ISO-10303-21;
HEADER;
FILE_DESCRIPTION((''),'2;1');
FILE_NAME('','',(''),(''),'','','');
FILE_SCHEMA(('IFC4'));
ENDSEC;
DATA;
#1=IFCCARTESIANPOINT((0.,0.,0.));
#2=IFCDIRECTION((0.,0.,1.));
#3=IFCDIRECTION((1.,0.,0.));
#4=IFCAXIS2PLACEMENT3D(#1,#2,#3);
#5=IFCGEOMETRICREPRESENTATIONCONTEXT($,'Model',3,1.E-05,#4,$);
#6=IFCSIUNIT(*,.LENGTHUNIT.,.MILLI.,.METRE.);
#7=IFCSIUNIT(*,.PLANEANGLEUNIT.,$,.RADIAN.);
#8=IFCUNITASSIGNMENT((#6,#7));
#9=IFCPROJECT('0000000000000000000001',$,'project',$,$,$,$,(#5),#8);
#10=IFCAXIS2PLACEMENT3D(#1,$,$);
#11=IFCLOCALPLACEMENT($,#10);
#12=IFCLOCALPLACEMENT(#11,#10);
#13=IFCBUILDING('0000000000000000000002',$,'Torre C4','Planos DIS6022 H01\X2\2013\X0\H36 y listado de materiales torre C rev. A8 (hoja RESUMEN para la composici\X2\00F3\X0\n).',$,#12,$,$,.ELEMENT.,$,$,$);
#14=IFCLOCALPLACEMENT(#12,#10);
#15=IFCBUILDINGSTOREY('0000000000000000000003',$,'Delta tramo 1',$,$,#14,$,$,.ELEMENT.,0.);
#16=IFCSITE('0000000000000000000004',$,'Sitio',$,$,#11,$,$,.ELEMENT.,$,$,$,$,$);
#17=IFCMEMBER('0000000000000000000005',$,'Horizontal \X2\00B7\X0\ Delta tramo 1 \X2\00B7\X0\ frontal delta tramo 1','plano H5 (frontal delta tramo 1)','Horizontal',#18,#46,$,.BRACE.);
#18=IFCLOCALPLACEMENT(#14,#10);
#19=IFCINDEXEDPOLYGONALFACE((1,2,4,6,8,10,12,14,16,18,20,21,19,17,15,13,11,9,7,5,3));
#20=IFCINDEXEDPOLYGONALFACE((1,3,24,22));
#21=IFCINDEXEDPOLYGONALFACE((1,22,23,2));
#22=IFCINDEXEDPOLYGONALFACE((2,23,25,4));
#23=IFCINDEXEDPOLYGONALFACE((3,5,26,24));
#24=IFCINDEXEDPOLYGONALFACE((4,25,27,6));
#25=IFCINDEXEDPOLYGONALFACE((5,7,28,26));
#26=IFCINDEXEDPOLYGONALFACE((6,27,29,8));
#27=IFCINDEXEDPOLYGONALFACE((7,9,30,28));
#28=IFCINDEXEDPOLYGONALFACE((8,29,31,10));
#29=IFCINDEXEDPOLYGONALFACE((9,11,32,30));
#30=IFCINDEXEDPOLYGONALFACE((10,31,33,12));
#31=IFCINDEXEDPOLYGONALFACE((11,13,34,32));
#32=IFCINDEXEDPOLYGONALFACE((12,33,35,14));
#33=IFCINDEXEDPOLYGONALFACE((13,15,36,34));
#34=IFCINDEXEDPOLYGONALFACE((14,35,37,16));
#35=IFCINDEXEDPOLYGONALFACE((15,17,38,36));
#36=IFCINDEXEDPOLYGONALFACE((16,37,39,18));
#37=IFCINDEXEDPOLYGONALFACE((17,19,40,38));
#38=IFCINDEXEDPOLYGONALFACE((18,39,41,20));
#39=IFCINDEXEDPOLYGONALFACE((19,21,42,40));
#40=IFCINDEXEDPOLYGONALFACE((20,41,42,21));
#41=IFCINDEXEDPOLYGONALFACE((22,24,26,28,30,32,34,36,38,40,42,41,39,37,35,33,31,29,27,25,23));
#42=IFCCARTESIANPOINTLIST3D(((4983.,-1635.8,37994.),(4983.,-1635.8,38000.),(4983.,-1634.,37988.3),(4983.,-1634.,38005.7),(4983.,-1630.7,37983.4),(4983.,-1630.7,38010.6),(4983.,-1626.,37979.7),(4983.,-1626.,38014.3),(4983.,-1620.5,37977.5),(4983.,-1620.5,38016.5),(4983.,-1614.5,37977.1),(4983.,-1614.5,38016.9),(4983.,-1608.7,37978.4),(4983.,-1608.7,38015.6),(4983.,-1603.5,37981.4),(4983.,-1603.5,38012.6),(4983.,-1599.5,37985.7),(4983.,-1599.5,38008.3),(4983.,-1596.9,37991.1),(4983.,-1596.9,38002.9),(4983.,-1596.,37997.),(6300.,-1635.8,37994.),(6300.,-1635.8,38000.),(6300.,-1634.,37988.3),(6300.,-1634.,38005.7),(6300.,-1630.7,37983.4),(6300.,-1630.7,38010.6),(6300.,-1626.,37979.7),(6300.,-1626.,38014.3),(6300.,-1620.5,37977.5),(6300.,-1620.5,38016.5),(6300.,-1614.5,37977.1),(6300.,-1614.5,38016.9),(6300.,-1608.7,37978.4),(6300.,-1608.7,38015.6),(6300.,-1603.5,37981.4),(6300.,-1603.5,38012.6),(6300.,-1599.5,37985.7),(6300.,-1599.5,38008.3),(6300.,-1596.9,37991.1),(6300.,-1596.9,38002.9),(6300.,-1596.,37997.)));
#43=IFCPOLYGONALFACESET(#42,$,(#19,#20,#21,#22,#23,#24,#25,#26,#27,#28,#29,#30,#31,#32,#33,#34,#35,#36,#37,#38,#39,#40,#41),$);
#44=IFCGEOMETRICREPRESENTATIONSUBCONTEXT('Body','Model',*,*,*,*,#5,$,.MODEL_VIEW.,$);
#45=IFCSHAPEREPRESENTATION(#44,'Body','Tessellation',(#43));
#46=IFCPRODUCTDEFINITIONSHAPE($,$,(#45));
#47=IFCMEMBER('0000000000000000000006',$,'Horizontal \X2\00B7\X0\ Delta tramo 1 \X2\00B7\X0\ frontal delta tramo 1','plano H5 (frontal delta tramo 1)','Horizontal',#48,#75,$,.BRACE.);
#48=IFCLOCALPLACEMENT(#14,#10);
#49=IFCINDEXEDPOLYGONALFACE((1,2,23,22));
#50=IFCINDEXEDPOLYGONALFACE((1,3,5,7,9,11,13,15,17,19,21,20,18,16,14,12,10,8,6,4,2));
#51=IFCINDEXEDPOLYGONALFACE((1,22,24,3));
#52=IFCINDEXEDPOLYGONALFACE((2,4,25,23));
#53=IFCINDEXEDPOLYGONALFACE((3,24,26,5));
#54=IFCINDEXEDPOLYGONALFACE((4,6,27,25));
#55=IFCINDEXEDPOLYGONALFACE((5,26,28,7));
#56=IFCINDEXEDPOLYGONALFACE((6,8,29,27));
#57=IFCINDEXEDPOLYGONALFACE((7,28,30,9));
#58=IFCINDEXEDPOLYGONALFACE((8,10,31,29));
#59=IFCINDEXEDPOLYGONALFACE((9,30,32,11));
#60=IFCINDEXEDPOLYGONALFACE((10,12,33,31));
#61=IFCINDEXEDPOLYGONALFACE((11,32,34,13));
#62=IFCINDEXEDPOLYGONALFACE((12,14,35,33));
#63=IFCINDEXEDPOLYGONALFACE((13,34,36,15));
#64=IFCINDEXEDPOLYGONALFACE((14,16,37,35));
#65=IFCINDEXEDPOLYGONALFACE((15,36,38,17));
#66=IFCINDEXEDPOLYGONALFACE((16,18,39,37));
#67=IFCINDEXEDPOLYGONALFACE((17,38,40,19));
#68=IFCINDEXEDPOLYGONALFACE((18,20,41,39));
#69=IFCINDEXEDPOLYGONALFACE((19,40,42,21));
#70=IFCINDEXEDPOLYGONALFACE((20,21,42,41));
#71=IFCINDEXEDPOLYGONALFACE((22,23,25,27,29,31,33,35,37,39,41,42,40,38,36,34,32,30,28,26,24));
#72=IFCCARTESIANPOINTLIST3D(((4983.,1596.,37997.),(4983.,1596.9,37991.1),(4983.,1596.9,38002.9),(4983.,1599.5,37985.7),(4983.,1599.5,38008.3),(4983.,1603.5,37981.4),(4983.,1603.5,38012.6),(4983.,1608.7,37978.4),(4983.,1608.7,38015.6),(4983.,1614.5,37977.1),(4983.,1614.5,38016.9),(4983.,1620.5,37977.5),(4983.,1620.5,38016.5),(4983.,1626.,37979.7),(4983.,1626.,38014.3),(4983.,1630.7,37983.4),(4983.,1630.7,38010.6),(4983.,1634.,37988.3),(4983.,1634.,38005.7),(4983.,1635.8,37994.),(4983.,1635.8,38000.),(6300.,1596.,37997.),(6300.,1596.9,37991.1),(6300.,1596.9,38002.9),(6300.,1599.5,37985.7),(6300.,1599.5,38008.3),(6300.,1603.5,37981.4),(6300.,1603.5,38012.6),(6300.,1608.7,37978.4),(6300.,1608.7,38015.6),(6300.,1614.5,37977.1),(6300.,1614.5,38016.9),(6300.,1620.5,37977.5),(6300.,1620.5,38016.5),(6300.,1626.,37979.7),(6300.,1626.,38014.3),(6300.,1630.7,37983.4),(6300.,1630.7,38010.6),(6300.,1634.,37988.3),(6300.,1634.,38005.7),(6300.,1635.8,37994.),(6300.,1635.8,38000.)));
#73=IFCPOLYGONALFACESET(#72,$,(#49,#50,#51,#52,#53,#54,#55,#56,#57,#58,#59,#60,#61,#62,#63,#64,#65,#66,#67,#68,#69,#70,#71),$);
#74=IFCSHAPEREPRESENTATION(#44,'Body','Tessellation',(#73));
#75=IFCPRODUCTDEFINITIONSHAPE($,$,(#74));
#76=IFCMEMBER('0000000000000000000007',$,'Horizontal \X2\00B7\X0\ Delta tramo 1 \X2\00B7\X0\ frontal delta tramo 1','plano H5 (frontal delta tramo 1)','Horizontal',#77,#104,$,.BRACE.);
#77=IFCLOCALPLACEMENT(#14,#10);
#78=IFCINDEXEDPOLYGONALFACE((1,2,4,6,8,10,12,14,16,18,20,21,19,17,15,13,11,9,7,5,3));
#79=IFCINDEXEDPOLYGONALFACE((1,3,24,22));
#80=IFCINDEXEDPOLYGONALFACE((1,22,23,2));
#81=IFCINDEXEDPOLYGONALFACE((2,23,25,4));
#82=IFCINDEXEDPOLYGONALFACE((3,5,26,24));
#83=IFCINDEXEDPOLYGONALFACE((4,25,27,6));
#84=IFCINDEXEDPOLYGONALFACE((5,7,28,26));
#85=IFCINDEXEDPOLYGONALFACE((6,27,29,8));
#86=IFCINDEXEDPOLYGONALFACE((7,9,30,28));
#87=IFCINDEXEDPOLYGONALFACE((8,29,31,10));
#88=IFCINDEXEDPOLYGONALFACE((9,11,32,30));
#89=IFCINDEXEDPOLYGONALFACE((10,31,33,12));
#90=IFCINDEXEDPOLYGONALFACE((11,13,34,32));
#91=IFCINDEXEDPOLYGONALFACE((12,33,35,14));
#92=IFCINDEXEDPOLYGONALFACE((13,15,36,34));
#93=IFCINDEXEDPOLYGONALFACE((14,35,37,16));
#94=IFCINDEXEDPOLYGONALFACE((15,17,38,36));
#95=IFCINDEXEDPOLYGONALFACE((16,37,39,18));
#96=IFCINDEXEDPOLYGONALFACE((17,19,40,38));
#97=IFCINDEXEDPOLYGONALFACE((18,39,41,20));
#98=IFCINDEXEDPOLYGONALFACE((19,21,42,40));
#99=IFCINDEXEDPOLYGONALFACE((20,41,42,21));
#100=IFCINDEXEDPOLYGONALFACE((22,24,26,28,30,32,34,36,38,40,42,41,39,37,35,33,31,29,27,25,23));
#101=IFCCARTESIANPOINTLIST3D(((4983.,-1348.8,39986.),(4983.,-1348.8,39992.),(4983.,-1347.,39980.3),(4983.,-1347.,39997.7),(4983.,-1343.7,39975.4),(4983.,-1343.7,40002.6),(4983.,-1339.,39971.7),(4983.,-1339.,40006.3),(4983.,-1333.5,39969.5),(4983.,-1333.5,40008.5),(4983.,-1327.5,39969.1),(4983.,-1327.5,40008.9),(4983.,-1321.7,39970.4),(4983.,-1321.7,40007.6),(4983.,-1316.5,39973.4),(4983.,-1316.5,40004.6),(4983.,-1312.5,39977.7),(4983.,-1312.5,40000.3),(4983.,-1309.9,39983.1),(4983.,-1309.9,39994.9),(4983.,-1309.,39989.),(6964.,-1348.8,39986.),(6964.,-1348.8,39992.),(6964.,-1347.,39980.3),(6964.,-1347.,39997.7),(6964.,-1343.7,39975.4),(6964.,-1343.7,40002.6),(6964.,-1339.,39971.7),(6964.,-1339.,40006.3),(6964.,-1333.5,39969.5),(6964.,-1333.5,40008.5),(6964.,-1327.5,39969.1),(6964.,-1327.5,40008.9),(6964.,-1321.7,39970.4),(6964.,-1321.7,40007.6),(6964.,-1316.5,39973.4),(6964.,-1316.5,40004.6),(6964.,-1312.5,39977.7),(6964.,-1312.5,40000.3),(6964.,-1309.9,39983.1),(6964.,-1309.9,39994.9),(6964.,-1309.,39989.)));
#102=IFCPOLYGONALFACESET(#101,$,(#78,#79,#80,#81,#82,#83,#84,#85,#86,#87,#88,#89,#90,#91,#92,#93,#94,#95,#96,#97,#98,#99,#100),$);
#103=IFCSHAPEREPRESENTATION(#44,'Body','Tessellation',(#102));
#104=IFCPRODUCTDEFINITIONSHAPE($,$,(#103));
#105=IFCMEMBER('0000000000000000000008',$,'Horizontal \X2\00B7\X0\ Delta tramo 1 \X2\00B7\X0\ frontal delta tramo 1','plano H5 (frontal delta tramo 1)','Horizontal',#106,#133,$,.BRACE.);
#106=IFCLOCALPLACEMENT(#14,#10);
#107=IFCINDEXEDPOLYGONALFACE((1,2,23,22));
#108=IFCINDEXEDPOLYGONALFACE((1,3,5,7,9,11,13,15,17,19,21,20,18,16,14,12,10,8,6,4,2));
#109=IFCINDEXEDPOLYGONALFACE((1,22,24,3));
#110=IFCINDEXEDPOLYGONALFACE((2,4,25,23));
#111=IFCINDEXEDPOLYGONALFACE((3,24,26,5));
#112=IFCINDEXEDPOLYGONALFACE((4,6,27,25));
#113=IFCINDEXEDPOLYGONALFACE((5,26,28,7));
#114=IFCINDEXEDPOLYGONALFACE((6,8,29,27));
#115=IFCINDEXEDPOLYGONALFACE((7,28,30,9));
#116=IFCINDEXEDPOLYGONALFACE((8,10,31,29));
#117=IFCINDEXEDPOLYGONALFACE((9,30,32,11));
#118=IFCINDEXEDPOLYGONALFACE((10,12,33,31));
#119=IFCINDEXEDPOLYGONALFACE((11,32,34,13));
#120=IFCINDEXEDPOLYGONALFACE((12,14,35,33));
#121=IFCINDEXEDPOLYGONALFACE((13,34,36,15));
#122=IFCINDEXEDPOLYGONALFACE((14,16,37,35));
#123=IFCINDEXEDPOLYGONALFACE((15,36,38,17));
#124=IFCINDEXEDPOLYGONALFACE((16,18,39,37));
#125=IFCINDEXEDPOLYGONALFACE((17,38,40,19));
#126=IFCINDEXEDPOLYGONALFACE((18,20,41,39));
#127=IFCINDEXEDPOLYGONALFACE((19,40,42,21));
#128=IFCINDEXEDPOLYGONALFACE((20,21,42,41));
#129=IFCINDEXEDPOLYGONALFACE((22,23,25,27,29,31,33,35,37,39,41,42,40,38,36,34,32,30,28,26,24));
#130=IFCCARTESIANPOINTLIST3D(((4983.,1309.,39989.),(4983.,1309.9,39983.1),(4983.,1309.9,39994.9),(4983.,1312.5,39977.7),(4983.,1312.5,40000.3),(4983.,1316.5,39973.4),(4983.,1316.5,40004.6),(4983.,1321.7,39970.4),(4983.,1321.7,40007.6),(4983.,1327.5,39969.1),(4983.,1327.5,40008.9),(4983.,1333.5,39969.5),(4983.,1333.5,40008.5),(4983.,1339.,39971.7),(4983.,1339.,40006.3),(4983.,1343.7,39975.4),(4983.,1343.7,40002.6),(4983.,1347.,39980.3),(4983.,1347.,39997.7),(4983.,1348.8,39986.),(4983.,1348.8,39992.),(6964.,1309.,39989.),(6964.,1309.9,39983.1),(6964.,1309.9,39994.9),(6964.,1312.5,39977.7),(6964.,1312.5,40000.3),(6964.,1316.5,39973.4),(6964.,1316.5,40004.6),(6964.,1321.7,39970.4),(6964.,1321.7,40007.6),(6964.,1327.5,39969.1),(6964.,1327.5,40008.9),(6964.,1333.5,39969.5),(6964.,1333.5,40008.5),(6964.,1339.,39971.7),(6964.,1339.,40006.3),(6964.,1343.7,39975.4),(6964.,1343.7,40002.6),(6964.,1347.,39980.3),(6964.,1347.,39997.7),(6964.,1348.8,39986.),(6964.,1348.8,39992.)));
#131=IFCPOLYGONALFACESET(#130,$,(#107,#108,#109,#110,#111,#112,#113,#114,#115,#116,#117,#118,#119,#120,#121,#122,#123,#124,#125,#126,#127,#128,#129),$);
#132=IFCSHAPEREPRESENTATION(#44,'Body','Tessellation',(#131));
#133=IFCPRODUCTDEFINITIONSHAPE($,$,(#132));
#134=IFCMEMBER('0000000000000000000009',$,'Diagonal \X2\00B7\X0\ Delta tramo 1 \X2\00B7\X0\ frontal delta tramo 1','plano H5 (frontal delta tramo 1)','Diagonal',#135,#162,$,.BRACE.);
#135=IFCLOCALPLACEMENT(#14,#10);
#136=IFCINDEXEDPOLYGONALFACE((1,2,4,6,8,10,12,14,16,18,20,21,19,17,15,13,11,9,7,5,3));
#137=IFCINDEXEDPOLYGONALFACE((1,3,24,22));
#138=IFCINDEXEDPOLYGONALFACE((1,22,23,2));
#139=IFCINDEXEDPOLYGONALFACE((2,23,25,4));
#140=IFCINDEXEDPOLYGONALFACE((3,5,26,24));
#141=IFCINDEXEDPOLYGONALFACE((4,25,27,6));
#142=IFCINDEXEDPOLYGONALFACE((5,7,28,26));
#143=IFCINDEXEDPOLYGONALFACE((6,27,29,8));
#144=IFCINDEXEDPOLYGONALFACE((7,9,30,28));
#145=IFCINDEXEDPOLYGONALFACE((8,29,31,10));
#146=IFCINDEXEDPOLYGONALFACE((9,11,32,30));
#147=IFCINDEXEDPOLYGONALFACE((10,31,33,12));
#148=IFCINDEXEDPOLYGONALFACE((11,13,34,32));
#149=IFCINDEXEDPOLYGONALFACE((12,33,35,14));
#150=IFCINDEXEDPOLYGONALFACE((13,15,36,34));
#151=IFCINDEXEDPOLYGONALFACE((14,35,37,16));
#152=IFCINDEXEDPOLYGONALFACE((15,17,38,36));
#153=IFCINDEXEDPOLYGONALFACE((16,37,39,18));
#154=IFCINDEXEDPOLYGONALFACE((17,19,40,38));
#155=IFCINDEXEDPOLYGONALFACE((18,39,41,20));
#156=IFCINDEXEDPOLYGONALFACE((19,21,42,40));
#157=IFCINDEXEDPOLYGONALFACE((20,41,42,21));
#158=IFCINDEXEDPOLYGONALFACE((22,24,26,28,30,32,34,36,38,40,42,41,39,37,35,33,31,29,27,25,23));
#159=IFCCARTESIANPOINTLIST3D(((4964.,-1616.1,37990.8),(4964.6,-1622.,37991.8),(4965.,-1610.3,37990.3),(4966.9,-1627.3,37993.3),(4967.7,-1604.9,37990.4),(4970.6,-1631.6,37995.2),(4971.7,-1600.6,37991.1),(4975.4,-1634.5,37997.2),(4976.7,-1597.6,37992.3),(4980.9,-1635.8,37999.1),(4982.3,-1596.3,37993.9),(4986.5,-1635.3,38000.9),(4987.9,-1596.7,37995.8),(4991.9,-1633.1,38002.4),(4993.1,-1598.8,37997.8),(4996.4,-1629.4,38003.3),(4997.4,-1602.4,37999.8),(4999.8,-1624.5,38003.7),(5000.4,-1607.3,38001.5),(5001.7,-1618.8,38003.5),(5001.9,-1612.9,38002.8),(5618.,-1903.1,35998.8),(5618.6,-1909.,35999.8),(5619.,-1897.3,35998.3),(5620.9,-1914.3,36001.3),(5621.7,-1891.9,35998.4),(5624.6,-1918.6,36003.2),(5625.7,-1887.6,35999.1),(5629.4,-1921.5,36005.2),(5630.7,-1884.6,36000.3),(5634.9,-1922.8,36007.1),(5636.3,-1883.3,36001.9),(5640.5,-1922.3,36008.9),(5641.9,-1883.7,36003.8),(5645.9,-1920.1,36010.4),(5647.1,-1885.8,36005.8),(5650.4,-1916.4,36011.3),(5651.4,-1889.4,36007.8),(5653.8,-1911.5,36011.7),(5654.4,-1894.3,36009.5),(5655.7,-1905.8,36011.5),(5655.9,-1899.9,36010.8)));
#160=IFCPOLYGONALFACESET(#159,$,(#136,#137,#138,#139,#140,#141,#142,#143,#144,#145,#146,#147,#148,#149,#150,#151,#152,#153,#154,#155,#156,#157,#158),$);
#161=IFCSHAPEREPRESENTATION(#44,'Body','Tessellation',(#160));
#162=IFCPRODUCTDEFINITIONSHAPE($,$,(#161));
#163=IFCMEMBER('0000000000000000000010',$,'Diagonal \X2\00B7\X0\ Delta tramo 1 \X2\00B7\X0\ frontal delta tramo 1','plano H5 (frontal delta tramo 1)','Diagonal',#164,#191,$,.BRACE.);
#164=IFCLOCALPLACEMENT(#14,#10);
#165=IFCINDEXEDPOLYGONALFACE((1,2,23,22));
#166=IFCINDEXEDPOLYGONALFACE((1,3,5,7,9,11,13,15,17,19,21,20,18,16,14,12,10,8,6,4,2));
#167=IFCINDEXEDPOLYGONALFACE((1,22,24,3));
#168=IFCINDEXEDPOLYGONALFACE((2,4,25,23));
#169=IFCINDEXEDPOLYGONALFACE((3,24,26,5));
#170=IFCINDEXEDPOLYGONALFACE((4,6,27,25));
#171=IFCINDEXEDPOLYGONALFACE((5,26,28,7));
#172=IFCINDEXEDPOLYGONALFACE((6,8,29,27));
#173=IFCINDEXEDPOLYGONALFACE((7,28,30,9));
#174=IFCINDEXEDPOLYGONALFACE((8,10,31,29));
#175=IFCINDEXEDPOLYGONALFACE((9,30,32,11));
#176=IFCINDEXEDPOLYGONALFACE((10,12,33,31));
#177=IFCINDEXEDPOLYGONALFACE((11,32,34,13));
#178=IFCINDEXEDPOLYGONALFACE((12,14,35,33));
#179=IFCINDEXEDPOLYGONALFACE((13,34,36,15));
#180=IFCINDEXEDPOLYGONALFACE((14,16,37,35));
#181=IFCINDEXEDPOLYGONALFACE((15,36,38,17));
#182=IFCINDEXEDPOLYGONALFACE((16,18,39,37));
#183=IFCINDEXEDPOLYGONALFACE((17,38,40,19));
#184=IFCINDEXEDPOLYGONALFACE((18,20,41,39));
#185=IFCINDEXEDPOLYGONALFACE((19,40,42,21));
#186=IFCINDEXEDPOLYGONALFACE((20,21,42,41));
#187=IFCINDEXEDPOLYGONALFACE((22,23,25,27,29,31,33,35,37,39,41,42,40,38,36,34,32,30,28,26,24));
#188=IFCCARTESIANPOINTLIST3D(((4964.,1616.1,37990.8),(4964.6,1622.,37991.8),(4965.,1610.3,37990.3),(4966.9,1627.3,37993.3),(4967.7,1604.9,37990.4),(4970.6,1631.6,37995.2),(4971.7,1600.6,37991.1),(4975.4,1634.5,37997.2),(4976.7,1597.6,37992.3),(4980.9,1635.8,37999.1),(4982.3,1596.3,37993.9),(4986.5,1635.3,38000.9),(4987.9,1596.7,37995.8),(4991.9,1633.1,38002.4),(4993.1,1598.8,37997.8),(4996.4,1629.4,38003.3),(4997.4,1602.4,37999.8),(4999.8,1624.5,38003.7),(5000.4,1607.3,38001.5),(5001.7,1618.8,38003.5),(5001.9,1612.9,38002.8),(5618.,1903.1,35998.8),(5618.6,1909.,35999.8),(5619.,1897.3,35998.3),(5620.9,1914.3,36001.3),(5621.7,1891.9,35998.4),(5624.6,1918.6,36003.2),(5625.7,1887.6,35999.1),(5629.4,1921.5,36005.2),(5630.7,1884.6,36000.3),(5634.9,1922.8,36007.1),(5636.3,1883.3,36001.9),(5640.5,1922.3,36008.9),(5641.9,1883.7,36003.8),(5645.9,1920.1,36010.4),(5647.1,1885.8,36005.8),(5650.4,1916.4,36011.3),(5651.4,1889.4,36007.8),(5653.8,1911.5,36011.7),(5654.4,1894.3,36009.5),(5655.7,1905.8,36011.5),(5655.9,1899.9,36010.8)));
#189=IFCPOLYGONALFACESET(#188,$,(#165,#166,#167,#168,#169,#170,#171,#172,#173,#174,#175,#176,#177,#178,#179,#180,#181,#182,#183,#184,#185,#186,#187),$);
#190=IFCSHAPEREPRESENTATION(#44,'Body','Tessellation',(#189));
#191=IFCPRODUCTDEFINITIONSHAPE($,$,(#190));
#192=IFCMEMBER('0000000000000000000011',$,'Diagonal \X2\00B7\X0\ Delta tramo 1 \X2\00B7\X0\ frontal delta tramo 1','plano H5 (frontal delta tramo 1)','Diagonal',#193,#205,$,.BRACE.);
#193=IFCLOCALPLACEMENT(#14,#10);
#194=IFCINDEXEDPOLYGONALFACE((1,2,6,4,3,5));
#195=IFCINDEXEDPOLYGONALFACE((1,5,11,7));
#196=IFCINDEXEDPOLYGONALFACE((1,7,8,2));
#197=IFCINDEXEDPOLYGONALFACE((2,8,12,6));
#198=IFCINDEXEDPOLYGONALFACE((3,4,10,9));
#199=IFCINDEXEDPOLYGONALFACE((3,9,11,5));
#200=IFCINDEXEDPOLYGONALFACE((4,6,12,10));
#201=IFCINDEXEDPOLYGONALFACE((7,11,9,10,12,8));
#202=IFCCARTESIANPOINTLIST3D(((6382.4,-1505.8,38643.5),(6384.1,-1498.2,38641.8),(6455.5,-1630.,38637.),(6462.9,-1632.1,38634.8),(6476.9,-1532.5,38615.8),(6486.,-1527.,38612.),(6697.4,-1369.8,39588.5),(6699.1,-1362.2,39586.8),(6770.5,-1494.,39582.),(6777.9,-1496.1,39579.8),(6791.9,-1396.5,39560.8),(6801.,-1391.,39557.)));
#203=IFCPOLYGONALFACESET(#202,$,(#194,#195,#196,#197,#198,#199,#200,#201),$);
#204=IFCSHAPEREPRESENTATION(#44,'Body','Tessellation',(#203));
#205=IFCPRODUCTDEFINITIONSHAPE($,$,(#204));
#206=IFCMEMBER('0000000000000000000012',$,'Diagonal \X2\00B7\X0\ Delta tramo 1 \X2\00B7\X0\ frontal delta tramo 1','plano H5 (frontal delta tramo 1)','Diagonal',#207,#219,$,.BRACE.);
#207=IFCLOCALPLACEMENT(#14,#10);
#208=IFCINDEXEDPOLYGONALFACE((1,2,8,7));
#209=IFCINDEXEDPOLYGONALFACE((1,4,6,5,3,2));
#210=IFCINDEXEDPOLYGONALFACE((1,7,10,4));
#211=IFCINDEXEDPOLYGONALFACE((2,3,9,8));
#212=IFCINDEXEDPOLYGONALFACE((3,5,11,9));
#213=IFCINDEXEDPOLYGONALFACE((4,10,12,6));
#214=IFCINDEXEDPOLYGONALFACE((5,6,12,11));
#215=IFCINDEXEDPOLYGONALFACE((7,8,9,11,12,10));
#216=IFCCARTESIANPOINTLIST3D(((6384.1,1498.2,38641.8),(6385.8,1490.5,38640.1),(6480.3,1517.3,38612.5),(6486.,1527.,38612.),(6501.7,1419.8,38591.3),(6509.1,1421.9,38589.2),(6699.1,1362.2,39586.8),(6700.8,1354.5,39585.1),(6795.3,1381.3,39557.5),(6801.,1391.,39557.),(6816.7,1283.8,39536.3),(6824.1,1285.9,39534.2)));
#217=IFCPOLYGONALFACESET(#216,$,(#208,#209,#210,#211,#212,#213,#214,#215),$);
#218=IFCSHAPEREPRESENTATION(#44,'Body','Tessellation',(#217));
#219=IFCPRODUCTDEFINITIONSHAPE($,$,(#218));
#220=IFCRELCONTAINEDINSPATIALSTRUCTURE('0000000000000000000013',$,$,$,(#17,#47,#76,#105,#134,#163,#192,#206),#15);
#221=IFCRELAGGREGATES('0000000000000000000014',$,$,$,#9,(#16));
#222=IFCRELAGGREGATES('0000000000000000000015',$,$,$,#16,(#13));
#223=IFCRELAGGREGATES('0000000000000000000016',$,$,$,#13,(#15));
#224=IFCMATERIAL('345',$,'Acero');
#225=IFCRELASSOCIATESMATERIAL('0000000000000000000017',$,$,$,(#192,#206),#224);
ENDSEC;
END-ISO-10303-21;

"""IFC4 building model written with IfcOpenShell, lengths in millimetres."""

from ifc_helpers import new_model, si_unit, frame, frame_2d, origin, origin_with_axes, place, context, subcontext, project, spatial, circle, l_section, extrude, material, element, save


model = new_model("IFC4")

# Units and contexts
model_context = context("Model", 3, precision=1e-05, world=origin_with_axes())
body_context = subcontext(model_context, "Body", "Model", "MODEL_VIEW")
ifc_project = project(units=[si_unit("LENGTHUNIT", "METRE", prefix="MILLI"), si_unit("PLANEANGLEUNIT", "RADIAN")], contexts=[model_context])

# Site, building, storey
site_placement = place(None, origin())
site = spatial("IfcSite", under=ifc_project, at=site_placement, Name="Sitio", CompositionType="ELEMENT")
building_placement = place(site_placement, origin())
building = spatial("IfcBuilding", under=site, at=building_placement, Name="Torre C4", Description="Planos DIS6022 H01–H36 y listado de materiales torre C rev. A8 (hoja RESUMEN para la composición).", CompositionType="ELEMENT")
storey_placement = place(building_placement, origin())
storey = spatial("IfcBuildingStorey", under=building, at=storey_placement, Name="Delta tramo 1", CompositionType="ELEMENT", Elevation=0.0)

# Members
for number, where, z_axis, x_axis, name in (
    (1, (6300.0, -1616.0, 37997.0), (-1.0, 0.0, 0.0), (0.0, 1.0, 0.0), "Horizontal · Delta tramo 1 · frontal delta tramo 1"),
    (2, (6300.0, 1616.0, 37997.0), (-1.0, 0.0, 0.0), (0.0, -1.0, 0.0), "Horizontal · Delta tramo 1 · frontal delta tramo 1"),
):
    element("IfcMember", number, at=place(storey_placement, frame(where, z_axis=z_axis, x_axis=x_axis)), inside=storey, Name=name, Description="plano H5 (frontal delta tramo 1)", ObjectType="Horizontal", PredefinedType="BRACE", context=body_context, shape_type="SweptSolid", body=[
        extrude(circle(Radius=20.0), None, (0.0, 0.0, 1.0), 1317.0),
    ])
for number, where, z_axis, x_axis, name in (
    (3, (6964.0, -1329.0, 39989.0), (-1.0, 0.0, 0.0), (0.0, 1.0, 0.0), "Horizontal · Delta tramo 1 · frontal delta tramo 1"),
    (4, (6964.0, 1329.0, 39989.0), (-1.0, 0.0, 0.0), (0.0, -1.0, 0.0), "Horizontal · Delta tramo 1 · frontal delta tramo 1"),
):
    element("IfcMember", number, at=place(storey_placement, frame(where, z_axis=z_axis, x_axis=x_axis)), inside=storey, Name=name, Description="plano H5 (frontal delta tramo 1)", ObjectType="Horizontal", PredefinedType="BRACE", context=body_context, shape_type="SweptSolid", body=[
        extrude(circle(Radius=20.0), None, (0.0, 0.0, 1.0), 1981.0),
    ])
for number, where, z_axis, x_axis, name in (
    (5, (4983.0, -1616.0, 37997.0), (0.30905, -0.135623, -0.941326), (-0.897588, 0.28557, -0.335834), "Diagonal · Delta tramo 1 · frontal delta tramo 1"),
    (6, (4983.0, 1616.0, 37997.0), (0.30905, 0.135623, -0.941326), (-0.897588, -0.28557, -0.335834), "Diagonal · Delta tramo 1 · frontal delta tramo 1"),
):
    element("IfcMember", number, at=place(storey_placement, frame(where, z_axis=z_axis, x_axis=x_axis)), inside=storey, Name=name, Description="plano H5 (frontal delta tramo 1)", ObjectType="Diagonal", PredefinedType="BRACE", context=body_context, shape_type="SweptSolid", body=[
        extrude(circle(Radius=20.0), None, (0.0, 0.0, 1.0), 2116.2),
    ])
ifc_material_1 = material(Name="345", Category="Acero")
for number, where, z_axis, x_axis, name in (
    (7, (6486.0, -1527.0, 38612.0), (0.313321, 0.135275, 0.939963), (-0.926175, 0.262236, 0.270985), "Diagonal · Delta tramo 1 · frontal delta tramo 1"),
    (8, (6486.0, 1527.0, 38612.0), (0.313321, -0.135275, 0.939963), (-0.926175, -0.262236, 0.270985), "Diagonal · Delta tramo 1 · frontal delta tramo 1"),
):
    element("IfcMember", number, at=place(storey_placement, frame(where, z_axis=z_axis, x_axis=x_axis)), inside=storey, material=ifc_material_1, Name=name, Description="plano H5 (frontal delta tramo 1)", ObjectType="Diagonal", PredefinedType="BRACE", context=body_context, shape_type="SweptSolid", body=[
        extrude(l_section(Depth=110.0, Width=110.0, Thickness=8.0, at=frame_2d((55.0, 55.0))), None, (0.0, 0.0, 1.0), 1005.4),
    ])

save(model, "model.ifc")
